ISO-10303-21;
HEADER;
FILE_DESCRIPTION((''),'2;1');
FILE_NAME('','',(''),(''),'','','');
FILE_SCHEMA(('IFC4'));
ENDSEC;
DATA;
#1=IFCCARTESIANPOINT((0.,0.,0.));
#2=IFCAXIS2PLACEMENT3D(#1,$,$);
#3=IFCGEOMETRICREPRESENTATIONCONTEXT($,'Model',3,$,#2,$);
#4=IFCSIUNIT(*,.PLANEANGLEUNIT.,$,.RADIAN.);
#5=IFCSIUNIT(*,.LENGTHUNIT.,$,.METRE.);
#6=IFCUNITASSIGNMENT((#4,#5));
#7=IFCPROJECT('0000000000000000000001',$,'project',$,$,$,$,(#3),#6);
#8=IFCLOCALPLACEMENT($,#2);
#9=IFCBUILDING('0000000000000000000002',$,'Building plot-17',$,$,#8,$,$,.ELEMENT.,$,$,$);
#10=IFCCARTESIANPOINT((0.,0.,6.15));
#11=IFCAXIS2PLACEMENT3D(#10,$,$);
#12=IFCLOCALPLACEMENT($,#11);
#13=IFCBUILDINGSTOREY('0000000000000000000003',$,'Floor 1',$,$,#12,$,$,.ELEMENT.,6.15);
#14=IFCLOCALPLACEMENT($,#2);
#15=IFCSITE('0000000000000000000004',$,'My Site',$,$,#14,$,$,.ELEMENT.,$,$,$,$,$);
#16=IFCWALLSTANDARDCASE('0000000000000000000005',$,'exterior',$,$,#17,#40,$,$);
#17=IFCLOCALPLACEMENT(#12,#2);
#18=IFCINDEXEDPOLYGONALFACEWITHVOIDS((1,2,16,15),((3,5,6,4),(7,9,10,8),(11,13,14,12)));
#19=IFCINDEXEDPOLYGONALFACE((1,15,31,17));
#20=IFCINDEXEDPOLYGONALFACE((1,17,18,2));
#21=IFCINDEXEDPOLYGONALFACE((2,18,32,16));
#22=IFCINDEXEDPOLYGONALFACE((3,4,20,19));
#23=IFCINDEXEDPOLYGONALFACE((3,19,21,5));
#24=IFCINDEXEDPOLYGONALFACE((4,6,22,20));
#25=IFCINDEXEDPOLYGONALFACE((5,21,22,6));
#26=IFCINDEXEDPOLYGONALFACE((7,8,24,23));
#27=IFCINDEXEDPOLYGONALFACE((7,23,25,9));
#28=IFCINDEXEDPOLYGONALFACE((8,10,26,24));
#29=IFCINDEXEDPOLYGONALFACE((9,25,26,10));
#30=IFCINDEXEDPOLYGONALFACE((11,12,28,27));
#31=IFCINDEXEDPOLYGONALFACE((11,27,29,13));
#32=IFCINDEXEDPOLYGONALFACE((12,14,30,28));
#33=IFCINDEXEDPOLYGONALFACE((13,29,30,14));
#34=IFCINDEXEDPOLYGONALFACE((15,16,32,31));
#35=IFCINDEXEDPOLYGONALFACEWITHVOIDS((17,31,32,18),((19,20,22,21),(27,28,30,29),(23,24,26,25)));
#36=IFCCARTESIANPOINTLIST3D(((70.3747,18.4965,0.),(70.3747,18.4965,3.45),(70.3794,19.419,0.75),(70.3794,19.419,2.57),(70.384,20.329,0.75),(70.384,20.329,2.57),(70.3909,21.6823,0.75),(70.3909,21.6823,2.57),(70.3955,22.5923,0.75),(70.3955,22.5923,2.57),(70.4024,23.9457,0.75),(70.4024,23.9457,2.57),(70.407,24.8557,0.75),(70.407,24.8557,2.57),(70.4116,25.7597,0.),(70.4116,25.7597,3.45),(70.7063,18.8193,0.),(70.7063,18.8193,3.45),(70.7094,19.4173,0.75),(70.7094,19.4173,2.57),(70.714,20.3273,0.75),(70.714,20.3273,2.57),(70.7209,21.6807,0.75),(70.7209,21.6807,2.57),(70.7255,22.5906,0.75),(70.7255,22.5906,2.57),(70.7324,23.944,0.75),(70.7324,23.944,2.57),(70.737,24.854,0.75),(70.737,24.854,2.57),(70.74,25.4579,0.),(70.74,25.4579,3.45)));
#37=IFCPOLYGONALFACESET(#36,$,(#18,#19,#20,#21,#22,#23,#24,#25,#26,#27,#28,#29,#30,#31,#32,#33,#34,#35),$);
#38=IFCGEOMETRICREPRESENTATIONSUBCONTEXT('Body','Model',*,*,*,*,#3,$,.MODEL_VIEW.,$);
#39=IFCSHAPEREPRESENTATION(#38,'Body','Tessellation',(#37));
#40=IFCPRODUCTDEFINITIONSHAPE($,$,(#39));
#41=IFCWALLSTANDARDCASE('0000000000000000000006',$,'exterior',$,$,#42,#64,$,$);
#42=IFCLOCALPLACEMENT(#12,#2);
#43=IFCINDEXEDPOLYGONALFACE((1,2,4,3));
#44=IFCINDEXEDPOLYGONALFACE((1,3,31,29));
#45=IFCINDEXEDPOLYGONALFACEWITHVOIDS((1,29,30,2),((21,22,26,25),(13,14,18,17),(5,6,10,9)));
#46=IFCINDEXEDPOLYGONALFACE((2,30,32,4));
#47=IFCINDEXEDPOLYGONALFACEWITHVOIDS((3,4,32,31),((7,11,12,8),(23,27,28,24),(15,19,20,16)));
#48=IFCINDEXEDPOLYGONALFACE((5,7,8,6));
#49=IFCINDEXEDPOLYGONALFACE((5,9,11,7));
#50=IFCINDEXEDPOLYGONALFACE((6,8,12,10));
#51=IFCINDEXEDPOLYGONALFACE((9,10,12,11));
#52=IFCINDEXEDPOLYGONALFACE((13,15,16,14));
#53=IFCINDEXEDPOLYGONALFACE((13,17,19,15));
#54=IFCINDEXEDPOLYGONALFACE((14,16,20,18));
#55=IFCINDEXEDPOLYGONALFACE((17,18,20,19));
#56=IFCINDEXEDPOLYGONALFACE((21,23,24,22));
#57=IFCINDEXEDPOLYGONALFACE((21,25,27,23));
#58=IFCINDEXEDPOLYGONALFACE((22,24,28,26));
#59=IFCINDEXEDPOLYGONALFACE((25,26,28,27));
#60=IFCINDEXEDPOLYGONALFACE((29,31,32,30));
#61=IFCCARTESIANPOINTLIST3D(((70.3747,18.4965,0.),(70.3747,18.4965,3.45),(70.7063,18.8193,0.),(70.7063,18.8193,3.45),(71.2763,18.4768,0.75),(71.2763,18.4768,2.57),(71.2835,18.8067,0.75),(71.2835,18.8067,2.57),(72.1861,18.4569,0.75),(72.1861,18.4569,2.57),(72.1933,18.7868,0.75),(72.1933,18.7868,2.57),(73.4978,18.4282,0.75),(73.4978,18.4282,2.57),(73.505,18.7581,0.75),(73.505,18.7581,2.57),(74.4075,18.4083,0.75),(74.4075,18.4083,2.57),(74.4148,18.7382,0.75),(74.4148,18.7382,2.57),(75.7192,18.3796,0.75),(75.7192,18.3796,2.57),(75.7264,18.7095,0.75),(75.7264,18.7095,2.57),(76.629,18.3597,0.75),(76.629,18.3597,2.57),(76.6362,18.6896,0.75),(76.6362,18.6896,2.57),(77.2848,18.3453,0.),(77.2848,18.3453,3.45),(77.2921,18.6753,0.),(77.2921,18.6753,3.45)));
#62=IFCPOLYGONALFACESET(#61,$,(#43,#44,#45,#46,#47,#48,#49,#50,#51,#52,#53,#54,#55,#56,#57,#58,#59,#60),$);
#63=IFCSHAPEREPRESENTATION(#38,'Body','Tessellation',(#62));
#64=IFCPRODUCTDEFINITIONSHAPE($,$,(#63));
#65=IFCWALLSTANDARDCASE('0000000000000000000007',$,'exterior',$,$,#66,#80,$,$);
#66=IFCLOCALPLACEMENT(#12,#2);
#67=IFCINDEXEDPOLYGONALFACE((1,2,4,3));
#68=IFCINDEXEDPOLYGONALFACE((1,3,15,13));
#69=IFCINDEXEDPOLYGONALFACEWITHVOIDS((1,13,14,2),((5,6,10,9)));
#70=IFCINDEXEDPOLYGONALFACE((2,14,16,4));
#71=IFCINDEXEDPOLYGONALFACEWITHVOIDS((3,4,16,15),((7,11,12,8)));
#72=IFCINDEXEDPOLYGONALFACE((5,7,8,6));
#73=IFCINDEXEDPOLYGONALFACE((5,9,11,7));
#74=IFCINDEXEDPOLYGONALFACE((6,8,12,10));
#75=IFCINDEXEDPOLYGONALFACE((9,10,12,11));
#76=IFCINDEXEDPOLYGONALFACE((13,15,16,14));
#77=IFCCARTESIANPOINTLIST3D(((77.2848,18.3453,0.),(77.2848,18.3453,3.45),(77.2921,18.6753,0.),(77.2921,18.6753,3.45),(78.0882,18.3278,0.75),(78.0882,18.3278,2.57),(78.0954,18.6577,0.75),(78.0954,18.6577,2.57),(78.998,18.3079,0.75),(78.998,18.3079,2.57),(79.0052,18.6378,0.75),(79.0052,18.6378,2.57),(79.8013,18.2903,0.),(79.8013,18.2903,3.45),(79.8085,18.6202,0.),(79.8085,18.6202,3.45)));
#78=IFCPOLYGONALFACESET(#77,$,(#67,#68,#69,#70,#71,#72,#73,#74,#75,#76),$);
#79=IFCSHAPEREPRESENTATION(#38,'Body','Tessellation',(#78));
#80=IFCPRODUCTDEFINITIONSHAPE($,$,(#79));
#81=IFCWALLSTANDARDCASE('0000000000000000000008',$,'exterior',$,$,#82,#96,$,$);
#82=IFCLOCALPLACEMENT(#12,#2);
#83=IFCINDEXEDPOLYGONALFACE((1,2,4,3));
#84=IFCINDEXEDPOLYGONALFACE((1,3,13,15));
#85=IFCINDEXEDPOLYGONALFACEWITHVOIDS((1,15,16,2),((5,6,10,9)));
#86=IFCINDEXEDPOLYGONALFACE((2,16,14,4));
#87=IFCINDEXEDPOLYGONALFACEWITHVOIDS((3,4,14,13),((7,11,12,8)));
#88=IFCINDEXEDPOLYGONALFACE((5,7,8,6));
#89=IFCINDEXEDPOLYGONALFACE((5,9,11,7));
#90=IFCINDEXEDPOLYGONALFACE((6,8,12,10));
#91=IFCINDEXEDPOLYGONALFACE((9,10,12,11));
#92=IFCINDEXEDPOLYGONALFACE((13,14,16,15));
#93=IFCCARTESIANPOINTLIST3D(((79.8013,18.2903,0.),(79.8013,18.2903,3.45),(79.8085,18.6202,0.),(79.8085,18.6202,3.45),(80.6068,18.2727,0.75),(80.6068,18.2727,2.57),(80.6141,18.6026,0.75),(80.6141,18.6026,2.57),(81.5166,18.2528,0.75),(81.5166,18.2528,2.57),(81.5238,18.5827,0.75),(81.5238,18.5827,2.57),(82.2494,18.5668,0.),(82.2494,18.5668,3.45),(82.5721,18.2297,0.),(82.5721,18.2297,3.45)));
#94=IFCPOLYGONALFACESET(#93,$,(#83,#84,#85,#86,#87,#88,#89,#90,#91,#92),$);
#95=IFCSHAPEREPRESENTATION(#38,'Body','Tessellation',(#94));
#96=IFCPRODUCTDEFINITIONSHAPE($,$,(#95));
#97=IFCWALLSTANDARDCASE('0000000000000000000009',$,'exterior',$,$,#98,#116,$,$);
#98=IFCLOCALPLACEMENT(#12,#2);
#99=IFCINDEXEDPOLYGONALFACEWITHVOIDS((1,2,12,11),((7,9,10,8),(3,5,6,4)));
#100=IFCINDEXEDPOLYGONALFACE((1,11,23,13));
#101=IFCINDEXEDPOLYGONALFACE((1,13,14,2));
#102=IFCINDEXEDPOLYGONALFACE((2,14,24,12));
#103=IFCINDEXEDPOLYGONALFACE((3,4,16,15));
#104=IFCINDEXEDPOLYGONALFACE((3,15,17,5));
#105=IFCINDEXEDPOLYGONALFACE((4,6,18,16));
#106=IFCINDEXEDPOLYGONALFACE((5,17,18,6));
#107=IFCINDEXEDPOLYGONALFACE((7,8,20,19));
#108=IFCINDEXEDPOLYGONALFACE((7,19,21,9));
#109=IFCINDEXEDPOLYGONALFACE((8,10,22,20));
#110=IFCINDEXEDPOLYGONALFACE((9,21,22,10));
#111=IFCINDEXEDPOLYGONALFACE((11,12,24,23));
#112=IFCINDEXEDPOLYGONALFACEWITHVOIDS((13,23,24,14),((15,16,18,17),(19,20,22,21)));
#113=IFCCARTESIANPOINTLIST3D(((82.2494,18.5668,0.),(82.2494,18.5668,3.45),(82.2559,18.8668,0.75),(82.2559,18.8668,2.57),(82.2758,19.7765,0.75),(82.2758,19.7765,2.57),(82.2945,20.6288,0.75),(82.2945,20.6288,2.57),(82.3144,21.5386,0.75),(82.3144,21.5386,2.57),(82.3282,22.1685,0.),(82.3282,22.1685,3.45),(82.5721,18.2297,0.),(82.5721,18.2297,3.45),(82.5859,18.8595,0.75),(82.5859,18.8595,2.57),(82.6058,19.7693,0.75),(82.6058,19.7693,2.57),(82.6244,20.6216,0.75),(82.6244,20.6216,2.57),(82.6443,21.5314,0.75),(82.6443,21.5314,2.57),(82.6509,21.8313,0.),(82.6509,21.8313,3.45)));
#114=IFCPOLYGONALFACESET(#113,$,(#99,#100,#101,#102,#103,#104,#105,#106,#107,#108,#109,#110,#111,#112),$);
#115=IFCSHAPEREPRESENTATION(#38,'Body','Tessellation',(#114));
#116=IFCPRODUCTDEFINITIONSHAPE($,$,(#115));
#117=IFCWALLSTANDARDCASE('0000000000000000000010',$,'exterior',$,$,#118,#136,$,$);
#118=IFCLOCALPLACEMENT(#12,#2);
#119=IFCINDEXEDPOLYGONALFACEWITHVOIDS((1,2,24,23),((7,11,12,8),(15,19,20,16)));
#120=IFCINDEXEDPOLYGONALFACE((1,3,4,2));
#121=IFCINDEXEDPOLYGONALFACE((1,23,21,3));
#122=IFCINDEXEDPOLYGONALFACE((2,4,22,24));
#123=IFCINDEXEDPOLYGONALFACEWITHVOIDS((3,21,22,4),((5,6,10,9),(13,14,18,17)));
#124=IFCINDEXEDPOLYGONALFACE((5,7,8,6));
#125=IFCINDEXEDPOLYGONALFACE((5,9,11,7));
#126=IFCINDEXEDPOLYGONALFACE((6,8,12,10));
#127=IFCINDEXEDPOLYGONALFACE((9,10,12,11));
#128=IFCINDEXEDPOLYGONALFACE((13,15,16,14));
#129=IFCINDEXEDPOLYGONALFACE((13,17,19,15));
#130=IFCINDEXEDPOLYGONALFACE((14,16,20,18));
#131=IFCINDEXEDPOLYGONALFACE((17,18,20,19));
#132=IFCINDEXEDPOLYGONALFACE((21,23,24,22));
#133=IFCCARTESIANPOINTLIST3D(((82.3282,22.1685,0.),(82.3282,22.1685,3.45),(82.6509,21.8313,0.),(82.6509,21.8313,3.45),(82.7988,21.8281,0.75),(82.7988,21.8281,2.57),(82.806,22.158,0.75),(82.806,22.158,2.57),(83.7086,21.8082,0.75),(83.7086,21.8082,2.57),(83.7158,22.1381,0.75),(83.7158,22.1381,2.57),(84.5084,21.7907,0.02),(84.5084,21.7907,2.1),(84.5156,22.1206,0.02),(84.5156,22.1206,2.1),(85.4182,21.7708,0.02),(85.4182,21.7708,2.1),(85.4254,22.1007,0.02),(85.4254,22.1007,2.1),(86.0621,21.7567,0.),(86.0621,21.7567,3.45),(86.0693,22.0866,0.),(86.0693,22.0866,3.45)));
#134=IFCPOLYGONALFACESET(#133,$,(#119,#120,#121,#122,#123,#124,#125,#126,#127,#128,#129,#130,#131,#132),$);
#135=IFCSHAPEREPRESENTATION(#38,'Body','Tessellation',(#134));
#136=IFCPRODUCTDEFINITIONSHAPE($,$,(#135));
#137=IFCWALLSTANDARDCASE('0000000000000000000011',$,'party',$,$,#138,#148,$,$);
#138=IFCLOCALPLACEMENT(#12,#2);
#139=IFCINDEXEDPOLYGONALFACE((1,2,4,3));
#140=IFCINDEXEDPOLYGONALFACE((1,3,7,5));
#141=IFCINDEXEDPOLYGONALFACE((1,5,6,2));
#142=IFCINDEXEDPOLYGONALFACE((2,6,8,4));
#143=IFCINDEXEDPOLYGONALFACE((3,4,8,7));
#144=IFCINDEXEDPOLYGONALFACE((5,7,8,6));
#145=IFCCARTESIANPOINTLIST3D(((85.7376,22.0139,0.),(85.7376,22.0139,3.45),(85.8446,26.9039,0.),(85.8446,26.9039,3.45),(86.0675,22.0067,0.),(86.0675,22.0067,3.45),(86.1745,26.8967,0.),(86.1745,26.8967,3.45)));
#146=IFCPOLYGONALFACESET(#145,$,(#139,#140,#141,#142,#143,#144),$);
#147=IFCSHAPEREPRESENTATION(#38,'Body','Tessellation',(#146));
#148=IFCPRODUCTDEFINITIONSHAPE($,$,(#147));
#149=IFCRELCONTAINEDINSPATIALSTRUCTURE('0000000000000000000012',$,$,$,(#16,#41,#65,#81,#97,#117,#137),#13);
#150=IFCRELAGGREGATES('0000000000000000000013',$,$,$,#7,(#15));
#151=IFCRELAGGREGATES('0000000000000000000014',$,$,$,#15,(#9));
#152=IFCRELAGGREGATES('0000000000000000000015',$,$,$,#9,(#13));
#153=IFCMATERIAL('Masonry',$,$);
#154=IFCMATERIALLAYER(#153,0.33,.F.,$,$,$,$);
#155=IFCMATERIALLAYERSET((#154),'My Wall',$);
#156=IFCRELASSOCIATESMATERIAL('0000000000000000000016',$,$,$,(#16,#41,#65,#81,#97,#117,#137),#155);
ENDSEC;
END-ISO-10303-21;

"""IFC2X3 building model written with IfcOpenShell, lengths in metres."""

from ifc_helpers import new_model, si_unit, frame, origin, place, context, subcontext, project, spatial, polyline, outline, extrude, material, layer, layer_set, layer_usage, element, save


model = new_model("IFC2X3")

# Units and contexts
model_context = context("Model", 3, world=origin())
body_context = subcontext(model_context, "Body", "Model", "MODEL_VIEW")
ifc_project = project(units=[si_unit("PLANEANGLEUNIT", "RADIAN"), si_unit("LENGTHUNIT", "METRE")], contexts=[model_context])

# Site, building, storey
site_placement = place(None, origin())
site = spatial("IfcSite", under=ifc_project, at=site_placement, Name="My Site", CompositionType="ELEMENT")
building_placement = place(None, origin())
building = spatial("IfcBuilding", under=site, at=building_placement, Name="Building plot-17", CompositionType="ELEMENT")
storey_placement = place(None, frame((0.0, 0.0, 6.15)))
storey = spatial("IfcBuildingStorey", under=building, at=storey_placement, Name="Floor 1", CompositionType="ELEMENT", Elevation=6.15)

# Walls, openings
ifc_material_1 = material(Name="Masonry")
ifc_layer_1 = layer(ifc_material_1, 0.33, ventilated=False)
ifc_layer_set_1 = layer_set([ifc_layer_1], Name="My Wall")
ifc_layer_usage_1 = layer_usage(ifc_layer_set_1, "AXIS2", "NEGATIVE", 0.08)
wall_1_placement = place(storey_placement, origin())
wall_1 = element("IfcWallStandardCase", 1, at=wall_1_placement, inside=storey, material=ifc_layer_usage_1, Name="exterior", context=body_context, shape_type="SweptSolid", body=[
    extrude(outline(polyline([(70.74, 25.4579), (70.4116, 25.7597), (70.3747, 18.4965), (70.7063, 18.8193), (70.74, 25.4579)])), origin(), (0.0, 0.0, 1.0), 3.45),
])
opening_1_placement = place(storey_placement, frame((0.0, 0.0, 0.75)))
element("IfcOpeningElement", 2, at=opening_1_placement, cuts=wall_1, ObjectType="Opening", context=body_context, shape_type="SweptSolid", body=[
    extrude(outline(polyline([(70.407, 24.8557), (70.4024, 23.9457), (70.7324, 23.944), (70.737, 24.854), (70.407, 24.8557)])), origin(), (0.0, 0.0, 1.0), 1.82),
])
opening_2_placement = place(storey_placement, frame((0.0, 0.0, 0.75)))
element("IfcOpeningElement", 3, at=opening_2_placement, cuts=wall_1, ObjectType="Opening", context=body_context, shape_type="SweptSolid", body=[
    extrude(outline(polyline([(70.3955, 22.5923), (70.3909, 21.6823), (70.7209, 21.6807), (70.7255, 22.5906), (70.3955, 22.5923)])), origin(), (0.0, 0.0, 1.0), 1.82),
])
opening_3_placement = place(storey_placement, frame((0.0, 0.0, 0.75)))
element("IfcOpeningElement", 4, at=opening_3_placement, cuts=wall_1, ObjectType="Opening", context=body_context, shape_type="SweptSolid", body=[
    extrude(outline(polyline([(70.384, 20.329), (70.3794, 19.419), (70.7094, 19.4173), (70.714, 20.3273), (70.384, 20.329)])), origin(), (0.0, 0.0, 1.0), 1.82),
])
wall_2_placement = place(storey_placement, origin())
wall_2 = element("IfcWallStandardCase", 5, at=wall_2_placement, inside=storey, material=ifc_layer_usage_1, Name="exterior", context=body_context, shape_type="SweptSolid", body=[
    extrude(outline(polyline([(70.7063, 18.8193), (70.3747, 18.4965), (77.2848, 18.3453), (77.2921, 18.6753), (70.7063, 18.8193)])), origin(), (0.0, 0.0, 1.0), 3.45),
])
opening_4_placement = place(storey_placement, frame((0.0, 0.0, 0.75)))
element("IfcOpeningElement", 6, at=opening_4_placement, cuts=wall_2, ObjectType="Opening", context=body_context, shape_type="SweptSolid", body=[
    extrude(outline(polyline([(71.2763, 18.4768), (72.1861, 18.4569), (72.1933, 18.7868), (71.2835, 18.8067), (71.2763, 18.4768)])), origin(), (0.0, 0.0, 1.0), 1.82),
])
opening_5_placement = place(storey_placement, frame((0.0, 0.0, 0.75)))
element("IfcOpeningElement", 7, at=opening_5_placement, cuts=wall_2, ObjectType="Opening", context=body_context, shape_type="SweptSolid", body=[
    extrude(outline(polyline([(73.4978, 18.4282), (74.4075, 18.4083), (74.4148, 18.7382), (73.505, 18.7581), (73.4978, 18.4282)])), origin(), (0.0, 0.0, 1.0), 1.82),
])
opening_6_placement = place(storey_placement, frame((0.0, 0.0, 0.75)))
element("IfcOpeningElement", 8, at=opening_6_placement, cuts=wall_2, ObjectType="Opening", context=body_context, shape_type="SweptSolid", body=[
    extrude(outline(polyline([(75.7192, 18.3796), (76.629, 18.3597), (76.6362, 18.6896), (75.7264, 18.7095), (75.7192, 18.3796)])), origin(), (0.0, 0.0, 1.0), 1.82),
])

# Walls, openings
wall_3_placement = place(storey_placement, origin())
wall_3 = element("IfcWallStandardCase", 9, at=wall_3_placement, inside=storey, material=ifc_layer_usage_1, Name="exterior", context=body_context, shape_type="SweptSolid", body=[
    extrude(outline(polyline([(77.2921, 18.6753), (77.2848, 18.3453), (79.8013, 18.2903), (79.8085, 18.6202), (77.2921, 18.6753)])), origin(), (0.0, 0.0, 1.0), 3.45),
])
opening_7_placement = place(storey_placement, frame((0.0, 0.0, 0.75)))
element("IfcOpeningElement", 10, at=opening_7_placement, cuts=wall_3, ObjectType="Opening", context=body_context, shape_type="SweptSolid", body=[
    extrude(outline(polyline([(78.0882, 18.3278), (78.998, 18.3079), (79.0052, 18.6378), (78.0954, 18.6577), (78.0882, 18.3278)])), origin(), (0.0, 0.0, 1.0), 1.82),
])
wall_4_placement = place(storey_placement, origin())
wall_4 = element("IfcWallStandardCase", 11, at=wall_4_placement, inside=storey, material=ifc_layer_usage_1, Name="exterior", context=body_context, shape_type="SweptSolid", body=[
    extrude(outline(polyline([(79.8085, 18.6202), (79.8013, 18.2903), (82.5721, 18.2297), (82.2494, 18.5668), (79.8085, 18.6202)])), origin(), (0.0, 0.0, 1.0), 3.45),
])
opening_8_placement = place(storey_placement, frame((0.0, 0.0, 0.75)))
element("IfcOpeningElement", 12, at=opening_8_placement, cuts=wall_4, ObjectType="Opening", context=body_context, shape_type="SweptSolid", body=[
    extrude(outline(polyline([(80.6068, 18.2727), (81.5166, 18.2528), (81.5238, 18.5827), (80.6141, 18.6026), (80.6068, 18.2727)])), origin(), (0.0, 0.0, 1.0), 1.82),
])

# Walls, openings
wall_5_placement = place(storey_placement, origin())
wall_5 = element("IfcWallStandardCase", 13, at=wall_5_placement, inside=storey, material=ifc_layer_usage_1, Name="exterior", context=body_context, shape_type="SweptSolid", body=[
    extrude(outline(polyline([(82.2494, 18.5668), (82.5721, 18.2297), (82.6509, 21.8313), (82.3282, 22.1685), (82.2494, 18.5668)])), origin(), (0.0, 0.0, 1.0), 3.45),
])
opening_9_placement = place(storey_placement, frame((0.0, 0.0, 0.75)))
element("IfcOpeningElement", 14, at=opening_9_placement, cuts=wall_5, ObjectType="Opening", context=body_context, shape_type="SweptSolid", body=[
    extrude(outline(polyline([(82.5859, 18.8595), (82.6058, 19.7693), (82.2758, 19.7765), (82.2559, 18.8668), (82.5859, 18.8595)])), origin(), (0.0, 0.0, 1.0), 1.82),
])
opening_10_placement = place(storey_placement, frame((0.0, 0.0, 0.75)))
element("IfcOpeningElement", 15, at=opening_10_placement, cuts=wall_5, ObjectType="Opening", context=body_context, shape_type="SweptSolid", body=[
    extrude(outline(polyline([(82.6244, 20.6216), (82.6443, 21.5314), (82.3144, 21.5386), (82.2945, 20.6288), (82.6244, 20.6216)])), origin(), (0.0, 0.0, 1.0), 1.82),
])
wall_6_placement = place(storey_placement, origin())
wall_6 = element("IfcWallStandardCase", 16, at=wall_6_placement, inside=storey, material=ifc_layer_usage_1, Name="exterior", context=body_context, shape_type="SweptSolid", body=[
    extrude(outline(polyline([(82.3282, 22.1685), (82.6509, 21.8313), (86.0621, 21.7567), (86.0693, 22.0866), (82.3282, 22.1685)])), origin(), (0.0, 0.0, 1.0), 3.45),
])
opening_11_placement = place(storey_placement, frame((0.0, 0.0, 0.75)))
element("IfcOpeningElement", 17, at=opening_11_placement, cuts=wall_6, ObjectType="Opening", context=body_context, shape_type="SweptSolid", body=[
    extrude(outline(polyline([(82.7988, 21.8281), (83.7086, 21.8082), (83.7158, 22.1381), (82.806, 22.158), (82.7988, 21.8281)])), origin(), (0.0, 0.0, 1.0), 1.82),
])
opening_12_placement = place(storey_placement, frame((0.0, 0.0, 0.02)))
element("IfcOpeningElement", 18, at=opening_12_placement, cuts=wall_6, ObjectType="Opening", context=body_context, shape_type="SweptSolid", body=[
    extrude(outline(polyline([(84.5084, 21.7907), (85.4182, 21.7708), (85.4254, 22.1007), (84.5156, 22.1206), (84.5084, 21.7907)])), origin(), (0.0, 0.0, 1.0), 2.08),
])

# Wall
wall_7_placement = place(storey_placement, origin())
element("IfcWallStandardCase", 19, at=wall_7_placement, inside=storey, material=ifc_layer_usage_1, Name="party", context=body_context, shape_type="SweptSolid", body=[
    extrude(outline(polyline([(85.7376, 22.0139), (86.0675, 22.0067), (86.1745, 26.8967), (85.8446, 26.9039), (85.7376, 22.0139)])), origin(), (0.0, 0.0, 1.0), 3.45),
])

save(model, "model.ifc")
